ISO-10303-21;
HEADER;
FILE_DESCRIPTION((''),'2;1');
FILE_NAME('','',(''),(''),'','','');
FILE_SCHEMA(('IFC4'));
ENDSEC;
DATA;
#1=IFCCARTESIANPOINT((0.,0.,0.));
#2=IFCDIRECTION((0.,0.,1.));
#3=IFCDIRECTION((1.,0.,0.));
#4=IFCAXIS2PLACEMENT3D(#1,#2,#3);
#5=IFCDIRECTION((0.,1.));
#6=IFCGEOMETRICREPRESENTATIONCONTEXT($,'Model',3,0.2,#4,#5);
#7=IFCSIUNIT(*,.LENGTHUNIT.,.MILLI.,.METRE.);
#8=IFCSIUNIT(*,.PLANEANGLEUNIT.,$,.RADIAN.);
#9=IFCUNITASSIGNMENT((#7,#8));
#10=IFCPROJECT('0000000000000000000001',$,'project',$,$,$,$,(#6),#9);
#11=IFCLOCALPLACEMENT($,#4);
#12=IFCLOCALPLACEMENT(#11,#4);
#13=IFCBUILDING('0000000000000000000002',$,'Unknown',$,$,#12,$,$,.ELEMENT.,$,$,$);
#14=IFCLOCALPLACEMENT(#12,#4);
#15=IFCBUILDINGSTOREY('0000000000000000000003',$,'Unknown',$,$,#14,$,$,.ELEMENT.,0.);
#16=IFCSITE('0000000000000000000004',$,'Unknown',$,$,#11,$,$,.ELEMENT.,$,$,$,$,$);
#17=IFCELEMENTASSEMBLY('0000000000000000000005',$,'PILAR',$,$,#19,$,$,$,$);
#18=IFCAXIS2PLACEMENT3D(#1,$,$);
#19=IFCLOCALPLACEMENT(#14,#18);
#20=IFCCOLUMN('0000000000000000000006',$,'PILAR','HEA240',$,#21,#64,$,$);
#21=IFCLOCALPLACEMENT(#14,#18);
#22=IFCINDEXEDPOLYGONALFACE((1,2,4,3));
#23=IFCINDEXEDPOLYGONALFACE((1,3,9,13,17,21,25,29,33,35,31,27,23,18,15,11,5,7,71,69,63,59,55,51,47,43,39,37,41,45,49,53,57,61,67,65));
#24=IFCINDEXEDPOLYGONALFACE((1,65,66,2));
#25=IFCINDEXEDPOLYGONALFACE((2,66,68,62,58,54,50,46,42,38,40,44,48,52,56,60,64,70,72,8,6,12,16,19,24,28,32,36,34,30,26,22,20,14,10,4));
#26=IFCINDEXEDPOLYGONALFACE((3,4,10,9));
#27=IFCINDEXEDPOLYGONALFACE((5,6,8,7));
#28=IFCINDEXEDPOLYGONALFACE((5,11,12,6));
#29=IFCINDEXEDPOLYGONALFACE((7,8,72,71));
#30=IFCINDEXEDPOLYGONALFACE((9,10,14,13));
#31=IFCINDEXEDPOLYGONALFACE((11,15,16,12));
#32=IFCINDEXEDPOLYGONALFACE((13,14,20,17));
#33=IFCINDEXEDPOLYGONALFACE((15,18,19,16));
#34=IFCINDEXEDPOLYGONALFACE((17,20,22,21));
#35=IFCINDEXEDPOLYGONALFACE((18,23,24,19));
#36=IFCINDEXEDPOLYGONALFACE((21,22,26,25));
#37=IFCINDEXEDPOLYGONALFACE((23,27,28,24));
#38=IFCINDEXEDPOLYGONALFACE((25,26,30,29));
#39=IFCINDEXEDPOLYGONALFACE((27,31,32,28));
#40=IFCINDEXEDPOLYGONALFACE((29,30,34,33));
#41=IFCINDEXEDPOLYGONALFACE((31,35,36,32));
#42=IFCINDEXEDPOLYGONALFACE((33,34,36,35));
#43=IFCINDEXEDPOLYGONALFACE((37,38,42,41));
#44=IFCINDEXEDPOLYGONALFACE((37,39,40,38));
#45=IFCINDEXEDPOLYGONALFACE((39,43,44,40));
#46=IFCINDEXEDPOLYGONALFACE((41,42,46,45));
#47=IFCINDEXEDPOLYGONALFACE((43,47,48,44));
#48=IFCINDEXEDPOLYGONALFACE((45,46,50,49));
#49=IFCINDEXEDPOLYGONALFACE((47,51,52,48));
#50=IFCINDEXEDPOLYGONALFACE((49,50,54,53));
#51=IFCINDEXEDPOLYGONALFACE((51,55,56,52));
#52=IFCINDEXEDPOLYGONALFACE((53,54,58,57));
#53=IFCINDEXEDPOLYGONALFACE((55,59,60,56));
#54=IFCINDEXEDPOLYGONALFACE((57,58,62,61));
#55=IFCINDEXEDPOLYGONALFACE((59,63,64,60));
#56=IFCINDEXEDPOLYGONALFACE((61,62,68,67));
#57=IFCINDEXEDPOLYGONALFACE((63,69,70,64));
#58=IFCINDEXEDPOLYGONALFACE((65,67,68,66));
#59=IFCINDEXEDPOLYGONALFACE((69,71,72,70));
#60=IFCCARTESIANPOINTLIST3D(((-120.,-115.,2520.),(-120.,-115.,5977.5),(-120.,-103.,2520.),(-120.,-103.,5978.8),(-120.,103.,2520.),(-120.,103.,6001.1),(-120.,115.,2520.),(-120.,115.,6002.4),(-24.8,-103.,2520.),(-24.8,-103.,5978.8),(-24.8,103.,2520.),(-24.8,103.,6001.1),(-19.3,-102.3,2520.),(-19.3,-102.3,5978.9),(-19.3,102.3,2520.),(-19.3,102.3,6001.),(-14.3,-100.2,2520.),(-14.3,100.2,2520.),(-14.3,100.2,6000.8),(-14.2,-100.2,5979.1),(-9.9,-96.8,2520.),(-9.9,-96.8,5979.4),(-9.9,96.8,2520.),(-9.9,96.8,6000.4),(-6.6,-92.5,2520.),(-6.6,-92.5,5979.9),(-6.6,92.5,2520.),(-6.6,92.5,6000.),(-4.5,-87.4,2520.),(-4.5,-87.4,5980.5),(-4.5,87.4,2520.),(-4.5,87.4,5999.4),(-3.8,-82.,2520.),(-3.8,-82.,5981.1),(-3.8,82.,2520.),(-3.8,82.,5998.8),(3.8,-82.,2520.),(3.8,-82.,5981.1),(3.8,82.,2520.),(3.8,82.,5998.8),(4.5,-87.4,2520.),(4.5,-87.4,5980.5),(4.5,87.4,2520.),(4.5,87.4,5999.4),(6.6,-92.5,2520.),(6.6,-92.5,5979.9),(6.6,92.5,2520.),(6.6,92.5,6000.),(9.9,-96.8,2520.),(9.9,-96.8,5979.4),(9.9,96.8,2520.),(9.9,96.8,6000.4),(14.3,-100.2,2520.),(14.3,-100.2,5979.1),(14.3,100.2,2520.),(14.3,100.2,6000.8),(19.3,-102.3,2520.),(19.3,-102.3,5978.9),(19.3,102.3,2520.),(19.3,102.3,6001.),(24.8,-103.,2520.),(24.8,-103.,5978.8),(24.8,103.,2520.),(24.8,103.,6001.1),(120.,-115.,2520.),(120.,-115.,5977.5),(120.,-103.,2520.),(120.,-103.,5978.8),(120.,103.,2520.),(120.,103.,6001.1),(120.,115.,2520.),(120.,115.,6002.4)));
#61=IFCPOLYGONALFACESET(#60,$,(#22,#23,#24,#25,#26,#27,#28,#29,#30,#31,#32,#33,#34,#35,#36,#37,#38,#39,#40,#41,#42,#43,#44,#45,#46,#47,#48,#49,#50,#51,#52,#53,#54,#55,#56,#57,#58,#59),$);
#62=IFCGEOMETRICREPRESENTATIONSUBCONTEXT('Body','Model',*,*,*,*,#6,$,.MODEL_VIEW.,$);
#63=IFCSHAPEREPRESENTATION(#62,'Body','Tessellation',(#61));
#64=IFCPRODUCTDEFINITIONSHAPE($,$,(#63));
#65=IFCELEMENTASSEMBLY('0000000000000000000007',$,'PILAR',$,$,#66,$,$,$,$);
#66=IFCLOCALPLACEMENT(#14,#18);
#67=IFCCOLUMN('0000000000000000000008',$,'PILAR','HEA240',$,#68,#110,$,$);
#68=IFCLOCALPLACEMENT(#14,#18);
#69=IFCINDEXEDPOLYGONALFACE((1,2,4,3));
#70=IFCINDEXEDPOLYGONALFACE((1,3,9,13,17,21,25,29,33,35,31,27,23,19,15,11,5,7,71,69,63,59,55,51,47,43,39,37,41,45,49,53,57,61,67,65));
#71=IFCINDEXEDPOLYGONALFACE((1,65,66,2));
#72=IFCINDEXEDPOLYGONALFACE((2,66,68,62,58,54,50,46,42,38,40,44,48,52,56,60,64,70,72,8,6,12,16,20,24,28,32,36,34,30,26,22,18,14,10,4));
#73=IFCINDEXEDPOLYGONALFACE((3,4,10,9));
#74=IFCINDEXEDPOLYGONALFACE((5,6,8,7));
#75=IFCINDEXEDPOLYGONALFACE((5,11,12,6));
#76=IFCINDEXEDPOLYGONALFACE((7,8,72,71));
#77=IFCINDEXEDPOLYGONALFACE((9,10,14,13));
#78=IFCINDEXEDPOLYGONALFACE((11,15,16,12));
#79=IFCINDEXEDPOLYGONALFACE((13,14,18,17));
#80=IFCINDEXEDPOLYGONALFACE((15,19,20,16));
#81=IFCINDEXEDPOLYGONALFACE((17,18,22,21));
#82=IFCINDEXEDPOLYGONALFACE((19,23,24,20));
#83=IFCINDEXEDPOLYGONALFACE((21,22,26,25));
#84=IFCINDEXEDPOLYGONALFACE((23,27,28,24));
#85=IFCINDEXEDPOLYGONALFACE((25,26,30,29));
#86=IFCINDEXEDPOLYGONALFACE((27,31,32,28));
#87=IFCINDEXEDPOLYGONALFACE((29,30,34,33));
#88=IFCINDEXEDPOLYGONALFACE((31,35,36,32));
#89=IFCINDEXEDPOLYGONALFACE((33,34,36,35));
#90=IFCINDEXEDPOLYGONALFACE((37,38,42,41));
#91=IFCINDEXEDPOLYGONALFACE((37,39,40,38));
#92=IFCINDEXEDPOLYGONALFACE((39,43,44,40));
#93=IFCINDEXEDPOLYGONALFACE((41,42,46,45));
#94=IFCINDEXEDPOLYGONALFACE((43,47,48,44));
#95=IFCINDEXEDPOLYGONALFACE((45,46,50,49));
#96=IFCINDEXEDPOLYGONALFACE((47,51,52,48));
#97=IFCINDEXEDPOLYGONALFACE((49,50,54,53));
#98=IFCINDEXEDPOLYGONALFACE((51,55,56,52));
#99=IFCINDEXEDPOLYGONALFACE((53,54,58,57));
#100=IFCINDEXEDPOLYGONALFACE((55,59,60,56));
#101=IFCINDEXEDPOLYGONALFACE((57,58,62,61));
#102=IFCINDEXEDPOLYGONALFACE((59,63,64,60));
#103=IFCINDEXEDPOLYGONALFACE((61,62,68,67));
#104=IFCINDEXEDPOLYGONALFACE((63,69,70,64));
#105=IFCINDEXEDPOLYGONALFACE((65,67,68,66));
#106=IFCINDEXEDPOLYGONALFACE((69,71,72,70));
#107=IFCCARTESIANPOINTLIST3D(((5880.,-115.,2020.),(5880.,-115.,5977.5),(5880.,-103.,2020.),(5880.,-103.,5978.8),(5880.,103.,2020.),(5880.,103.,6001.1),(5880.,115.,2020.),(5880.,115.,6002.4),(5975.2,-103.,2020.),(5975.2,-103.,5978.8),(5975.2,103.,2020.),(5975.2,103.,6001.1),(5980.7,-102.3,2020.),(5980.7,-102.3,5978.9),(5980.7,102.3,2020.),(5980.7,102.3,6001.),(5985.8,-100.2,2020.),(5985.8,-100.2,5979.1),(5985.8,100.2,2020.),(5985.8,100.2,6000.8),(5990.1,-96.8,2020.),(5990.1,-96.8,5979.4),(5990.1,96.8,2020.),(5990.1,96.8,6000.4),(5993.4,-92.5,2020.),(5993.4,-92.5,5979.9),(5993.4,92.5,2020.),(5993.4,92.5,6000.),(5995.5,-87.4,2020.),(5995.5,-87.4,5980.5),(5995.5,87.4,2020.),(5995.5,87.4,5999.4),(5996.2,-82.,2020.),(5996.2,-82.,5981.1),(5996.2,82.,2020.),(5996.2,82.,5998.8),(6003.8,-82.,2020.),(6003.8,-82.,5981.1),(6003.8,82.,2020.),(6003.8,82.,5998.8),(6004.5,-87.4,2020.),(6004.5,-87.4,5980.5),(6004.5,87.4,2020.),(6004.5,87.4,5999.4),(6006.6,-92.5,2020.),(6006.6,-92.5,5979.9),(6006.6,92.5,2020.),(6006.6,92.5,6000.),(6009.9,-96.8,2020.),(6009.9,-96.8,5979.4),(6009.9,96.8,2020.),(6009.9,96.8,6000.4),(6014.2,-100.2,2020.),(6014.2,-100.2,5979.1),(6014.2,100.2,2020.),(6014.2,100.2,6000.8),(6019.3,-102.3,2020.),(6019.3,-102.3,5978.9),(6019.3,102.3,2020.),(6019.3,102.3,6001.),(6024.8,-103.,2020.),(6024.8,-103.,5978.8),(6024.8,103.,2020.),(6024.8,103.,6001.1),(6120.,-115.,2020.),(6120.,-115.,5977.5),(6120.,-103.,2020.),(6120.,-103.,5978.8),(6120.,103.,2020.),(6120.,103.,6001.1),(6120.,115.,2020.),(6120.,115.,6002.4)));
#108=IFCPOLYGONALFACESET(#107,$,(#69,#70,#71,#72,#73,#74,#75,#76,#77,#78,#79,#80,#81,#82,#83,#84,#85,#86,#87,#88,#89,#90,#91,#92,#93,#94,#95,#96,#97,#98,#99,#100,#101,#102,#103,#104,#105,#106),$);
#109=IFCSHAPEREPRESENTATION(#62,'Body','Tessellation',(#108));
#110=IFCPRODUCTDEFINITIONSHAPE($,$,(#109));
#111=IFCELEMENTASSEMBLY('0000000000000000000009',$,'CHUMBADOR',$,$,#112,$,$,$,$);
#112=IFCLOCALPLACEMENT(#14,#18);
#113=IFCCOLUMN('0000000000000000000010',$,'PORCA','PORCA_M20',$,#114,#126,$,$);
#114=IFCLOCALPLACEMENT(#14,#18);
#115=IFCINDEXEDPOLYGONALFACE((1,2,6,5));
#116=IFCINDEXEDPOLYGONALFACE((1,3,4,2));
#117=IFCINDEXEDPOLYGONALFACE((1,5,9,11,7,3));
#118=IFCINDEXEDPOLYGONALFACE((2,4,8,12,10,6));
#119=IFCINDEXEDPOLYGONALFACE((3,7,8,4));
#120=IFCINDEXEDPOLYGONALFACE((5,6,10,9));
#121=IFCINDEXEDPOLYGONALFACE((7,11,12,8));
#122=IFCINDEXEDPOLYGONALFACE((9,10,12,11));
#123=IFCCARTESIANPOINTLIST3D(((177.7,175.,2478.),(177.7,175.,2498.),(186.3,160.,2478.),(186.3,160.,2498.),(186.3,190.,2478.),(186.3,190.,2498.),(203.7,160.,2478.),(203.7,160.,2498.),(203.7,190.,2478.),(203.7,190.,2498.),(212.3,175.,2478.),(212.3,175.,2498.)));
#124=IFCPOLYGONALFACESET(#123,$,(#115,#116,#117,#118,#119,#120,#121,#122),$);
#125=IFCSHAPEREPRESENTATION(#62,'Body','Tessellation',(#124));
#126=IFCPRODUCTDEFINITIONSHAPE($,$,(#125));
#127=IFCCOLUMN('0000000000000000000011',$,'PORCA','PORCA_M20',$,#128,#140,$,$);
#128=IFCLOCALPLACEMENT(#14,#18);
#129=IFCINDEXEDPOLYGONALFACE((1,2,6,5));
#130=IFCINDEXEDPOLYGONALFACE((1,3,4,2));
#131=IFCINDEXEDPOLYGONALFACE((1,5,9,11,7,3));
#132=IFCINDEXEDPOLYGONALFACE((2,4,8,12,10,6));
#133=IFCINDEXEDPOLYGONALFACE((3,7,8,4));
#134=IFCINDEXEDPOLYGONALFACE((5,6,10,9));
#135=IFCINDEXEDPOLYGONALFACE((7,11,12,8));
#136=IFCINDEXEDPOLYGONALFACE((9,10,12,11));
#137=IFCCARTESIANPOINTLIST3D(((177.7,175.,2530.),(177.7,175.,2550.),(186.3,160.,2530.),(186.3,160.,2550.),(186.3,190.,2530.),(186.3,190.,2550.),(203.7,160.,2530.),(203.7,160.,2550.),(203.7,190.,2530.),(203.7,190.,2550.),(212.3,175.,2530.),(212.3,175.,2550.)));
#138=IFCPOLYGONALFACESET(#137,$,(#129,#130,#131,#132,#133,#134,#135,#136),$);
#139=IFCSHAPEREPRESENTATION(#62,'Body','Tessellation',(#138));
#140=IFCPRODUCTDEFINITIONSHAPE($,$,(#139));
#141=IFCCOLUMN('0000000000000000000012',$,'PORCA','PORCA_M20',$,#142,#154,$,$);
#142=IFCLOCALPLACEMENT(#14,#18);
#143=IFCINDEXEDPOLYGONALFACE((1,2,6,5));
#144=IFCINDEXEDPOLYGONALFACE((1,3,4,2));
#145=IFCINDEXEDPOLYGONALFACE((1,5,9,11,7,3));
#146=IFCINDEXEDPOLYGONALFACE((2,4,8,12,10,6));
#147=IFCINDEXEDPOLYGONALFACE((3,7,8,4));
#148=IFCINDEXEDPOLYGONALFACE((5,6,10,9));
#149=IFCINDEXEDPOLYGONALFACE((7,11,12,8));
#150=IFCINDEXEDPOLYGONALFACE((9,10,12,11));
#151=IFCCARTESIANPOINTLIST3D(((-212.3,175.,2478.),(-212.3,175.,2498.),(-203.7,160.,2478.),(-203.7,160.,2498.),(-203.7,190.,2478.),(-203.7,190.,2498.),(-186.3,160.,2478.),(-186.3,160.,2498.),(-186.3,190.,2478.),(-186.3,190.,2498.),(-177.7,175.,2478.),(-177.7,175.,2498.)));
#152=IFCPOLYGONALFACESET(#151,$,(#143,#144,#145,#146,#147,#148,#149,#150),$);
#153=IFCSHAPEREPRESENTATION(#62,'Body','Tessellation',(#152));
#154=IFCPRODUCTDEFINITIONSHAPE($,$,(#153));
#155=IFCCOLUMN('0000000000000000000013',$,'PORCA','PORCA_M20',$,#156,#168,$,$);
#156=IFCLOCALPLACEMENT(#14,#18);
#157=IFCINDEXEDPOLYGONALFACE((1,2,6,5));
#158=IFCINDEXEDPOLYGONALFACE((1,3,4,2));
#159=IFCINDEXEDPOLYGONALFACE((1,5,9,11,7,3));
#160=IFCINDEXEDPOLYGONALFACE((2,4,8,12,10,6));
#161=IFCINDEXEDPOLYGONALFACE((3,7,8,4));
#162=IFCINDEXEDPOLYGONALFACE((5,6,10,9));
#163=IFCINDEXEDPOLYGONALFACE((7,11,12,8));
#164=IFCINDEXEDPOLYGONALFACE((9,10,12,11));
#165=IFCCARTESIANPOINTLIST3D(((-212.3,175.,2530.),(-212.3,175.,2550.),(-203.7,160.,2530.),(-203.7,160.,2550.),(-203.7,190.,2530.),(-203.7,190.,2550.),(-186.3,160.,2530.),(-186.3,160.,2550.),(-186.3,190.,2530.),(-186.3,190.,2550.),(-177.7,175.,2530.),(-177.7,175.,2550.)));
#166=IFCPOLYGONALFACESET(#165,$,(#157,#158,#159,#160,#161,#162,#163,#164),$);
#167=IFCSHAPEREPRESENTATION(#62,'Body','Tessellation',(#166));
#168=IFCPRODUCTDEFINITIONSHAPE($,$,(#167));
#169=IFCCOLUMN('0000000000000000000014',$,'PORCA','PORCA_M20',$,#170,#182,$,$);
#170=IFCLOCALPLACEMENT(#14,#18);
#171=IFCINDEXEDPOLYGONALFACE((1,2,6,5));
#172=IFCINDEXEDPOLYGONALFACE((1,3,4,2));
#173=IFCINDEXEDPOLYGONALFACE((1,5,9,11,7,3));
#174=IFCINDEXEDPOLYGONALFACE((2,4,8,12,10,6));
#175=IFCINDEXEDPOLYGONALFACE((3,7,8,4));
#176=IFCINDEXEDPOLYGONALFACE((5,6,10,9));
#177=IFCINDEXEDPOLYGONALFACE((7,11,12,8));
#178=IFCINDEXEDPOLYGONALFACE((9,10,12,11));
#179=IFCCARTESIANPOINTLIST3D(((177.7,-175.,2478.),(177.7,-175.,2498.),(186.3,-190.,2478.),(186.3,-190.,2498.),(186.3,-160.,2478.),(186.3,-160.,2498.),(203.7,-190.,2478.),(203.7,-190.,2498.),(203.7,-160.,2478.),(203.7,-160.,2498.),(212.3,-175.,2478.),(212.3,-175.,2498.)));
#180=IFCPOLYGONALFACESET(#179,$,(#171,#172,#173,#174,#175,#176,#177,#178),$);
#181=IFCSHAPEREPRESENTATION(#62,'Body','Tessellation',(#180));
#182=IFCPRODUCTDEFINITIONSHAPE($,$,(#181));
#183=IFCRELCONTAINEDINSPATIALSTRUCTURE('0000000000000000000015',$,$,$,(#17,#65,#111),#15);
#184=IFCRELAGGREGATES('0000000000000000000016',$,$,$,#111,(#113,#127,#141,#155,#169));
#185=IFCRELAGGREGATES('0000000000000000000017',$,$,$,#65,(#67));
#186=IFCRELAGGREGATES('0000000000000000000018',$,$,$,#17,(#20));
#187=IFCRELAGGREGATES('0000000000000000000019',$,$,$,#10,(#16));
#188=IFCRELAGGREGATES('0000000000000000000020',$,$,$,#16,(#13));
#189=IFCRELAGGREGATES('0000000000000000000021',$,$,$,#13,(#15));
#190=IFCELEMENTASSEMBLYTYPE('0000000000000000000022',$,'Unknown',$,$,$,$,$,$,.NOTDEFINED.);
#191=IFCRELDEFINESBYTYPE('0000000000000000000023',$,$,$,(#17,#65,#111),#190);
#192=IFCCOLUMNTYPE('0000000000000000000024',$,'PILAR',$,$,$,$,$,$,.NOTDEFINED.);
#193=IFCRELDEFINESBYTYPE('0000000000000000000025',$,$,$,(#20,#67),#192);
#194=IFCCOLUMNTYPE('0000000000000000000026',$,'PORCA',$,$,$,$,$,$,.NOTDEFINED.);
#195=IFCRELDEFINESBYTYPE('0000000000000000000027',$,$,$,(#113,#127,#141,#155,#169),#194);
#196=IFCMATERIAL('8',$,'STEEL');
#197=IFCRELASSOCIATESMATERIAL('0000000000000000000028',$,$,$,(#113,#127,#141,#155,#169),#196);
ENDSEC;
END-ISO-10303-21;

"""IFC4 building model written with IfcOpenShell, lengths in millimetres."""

from ifc_helpers import new_model, si_unit, direction, frame, origin_with_axes, origin_2d_with_axis, place, context, subcontext, project, spatial, polyline, i_section, outline, extrude, clip, halfspace, material, material_profile, profile_set, profile_usage, type_object, element, aggregate, save


model = new_model("IFC4")

# Units and contexts
model_context = context("Model", 3, precision=0.2, world=origin_with_axes(), true_north=direction((0.0, 1.0)))
body_context = subcontext(model_context, "Body", "Model", "MODEL_VIEW")
ifc_project = project(units=[si_unit("LENGTHUNIT", "METRE", prefix="MILLI"), si_unit("PLANEANGLEUNIT", "RADIAN")], contexts=[model_context])

# Site, building, storey
site_placement = place(None, origin_with_axes())
site = spatial("IfcSite", under=ifc_project, at=site_placement, Name="Unknown", CompositionType="ELEMENT")
building_placement = place(site_placement, origin_with_axes())
building = spatial("IfcBuilding", under=site, at=building_placement, Name="Unknown", CompositionType="ELEMENT")
storey_placement = place(building_placement, origin_with_axes())
storey = spatial("IfcBuildingStorey", under=building, at=storey_placement, Name="Unknown", CompositionType="ELEMENT", Elevation=0.0)

# Element assemblies, columns
element_assembly_type = type_object("IfcElementAssemblyType", Name="Unknown", PredefinedType="NOTDEFINED")
assembly_1_placement = place(storey_placement, frame((0.0, 0.0, 2000.0), z_axis=(1.0, 0.0, 0.0), x_axis=(0.0, 0.0, 1.0)))
assembly_1 = element("IfcElementAssembly", 1, at=assembly_1_placement, inside=storey, type_object=element_assembly_type, Name="PILAR")
column_type_1 = type_object("IfcColumnType", Name="PILAR", PredefinedType="NOTDEFINED")
column_1_placement = place(assembly_1_placement, origin_with_axes())
column_1 = element("IfcColumn", 2, at=column_1_placement, type_object=column_type_1, Name="PILAR", Description="HEA240", context=body_context, shape_type="Clipping", body=[
    clip(clip(extrude(i_section(OverallWidth=240.0, OverallDepth=230.0, WebThickness=7.5, FlangeThickness=12.0, FilletRadius=21.0, FlangeEdgeRadius=0.0, FlangeSlope=0.0, at=origin_2d_with_axis()), frame((280.0, 0.0, 0.0), z_axis=(-1.0, 0.0, 0.0), x_axis=(0.0, 0.0, 1.0)), (0.0, 0.0, -1.0), 3949.9), halfspace(frame((520.0, -115.0, 0.0), z_axis=(1.0, 0.0, 0.0), x_axis=(0.0, 1.0, 0.0)), True)), halfspace(frame((3977.5, 115.0, 0.0), z_axis=(-0.994183, -0.107703, 0.0), x_axis=(0.107703, -0.994183, 0.0)), True)),
])
assembly_2_placement = place(storey_placement, frame((6000.0, 0.0, 2000.0), z_axis=(1.0, 0.0, 0.0), x_axis=(0.0, 0.0, 1.0)))
assembly_2 = element("IfcElementAssembly", 3, at=assembly_2_placement, inside=storey, type_object=element_assembly_type, Name="PILAR")
column_2_placement = place(assembly_2_placement, origin_with_axes())
column_2 = element("IfcColumn", 4, at=column_2_placement, type_object=column_type_1, Name="PILAR", Description="HEA240", context=body_context, shape_type="Clipping", body=[
    clip(clip(extrude(i_section(OverallWidth=240.0, OverallDepth=230.0, WebThickness=7.5, FlangeThickness=12.0, FilletRadius=21.0, FlangeEdgeRadius=0.0, FlangeSlope=0.0, at=origin_2d_with_axis()), frame((-220.0, 0.0, 0.0), z_axis=(-1.0, 0.0, 0.0), x_axis=(0.0, 0.0, 1.0)), (0.0, 0.0, -1.0), 4449.9), halfspace(frame((20.0, -115.0, 0.0), z_axis=(1.0, 0.0, 0.0), x_axis=(0.0, 1.0, 0.0)), True)), halfspace(frame((3977.5, 115.0, 0.0), z_axis=(-0.994183, -0.107703, 0.0), x_axis=(0.107703, -0.994183, 0.0)), True)),
])

# Element assembly, columns
assembly_3_placement = place(storey_placement, frame((-195.0, -175.0, 2445.0), z_axis=(1.0, 0.0, 0.0), x_axis=(0.0, 0.0, -1.0)))
assembly_3 = element("IfcElementAssembly", 5, at=assembly_3_placement, inside=storey, type_object=element_assembly_type, Name="CHUMBADOR")
ifc_material_1 = material(Name="8", Category="STEEL")
ifc_material_profile_1 = material_profile(ifc_material_1, outline(polyline([(8.7, -15.0), (17.3, 0.0), (8.7, 15.0), (-8.7, 15.0), (-17.3, 0.0), (-8.7, -15.0), (8.7, -15.0)])), Name="PORCA_M20")
ifc_profile_set_1 = profile_set([ifc_material_profile_1])
ifc_profile_usage_1 = profile_usage(ifc_profile_set_1, cardinal=5)
column_type_2 = type_object("IfcColumnType", Name="PORCA", PredefinedType="NOTDEFINED")
column_3_placement = place(assembly_3_placement, frame((-53.0, 350.0, 390.0), z_axis=(0.0, 0.0, 1.0), x_axis=(1.0, 0.0, 0.0)))
column_3 = element("IfcColumn", 6, at=column_3_placement, type_object=column_type_2, material=ifc_profile_usage_1, Name="PORCA", Description="PORCA_M20", context=body_context, shape_type="SolidModel", body=[
    extrude(outline(polyline([(8.7, -15.0), (17.3, 0.0), (8.7, 15.0), (-8.7, 15.0), (-17.3, 0.0), (-8.7, -15.0), (8.7, -15.0)])), frame((0.0, 0.0, 0.0), z_axis=(-1.0, 0.0, 0.0), x_axis=(0.0, 0.0, 1.0)), (0.0, 0.0, -1.0), 20.0),
])
column_4_placement = place(assembly_3_placement, frame((-105.0, 350.0, 390.0), z_axis=(0.0, 0.0, 1.0), x_axis=(1.0, 0.0, 0.0)))
column_4 = element("IfcColumn", 7, at=column_4_placement, type_object=column_type_2, material=ifc_profile_usage_1, Name="PORCA", Description="PORCA_M20", context=body_context, shape_type="SolidModel", body=[
    extrude(outline(polyline([(8.7, -15.0), (17.3, 0.0), (8.7, 15.0), (-8.7, 15.0), (-17.3, 0.0), (-8.7, -15.0), (8.7, -15.0)])), frame((0.0, 0.0, 0.0), z_axis=(-1.0, 0.0, 0.0), x_axis=(0.0, 0.0, 1.0)), (0.0, 0.0, -1.0), 20.0),
])
column_5_placement = place(assembly_3_placement, frame((-53.0, 350.0, 0.0), z_axis=(0.0, 0.0, -1.0), x_axis=(1.0, 0.0, 0.0)))
column_5 = element("IfcColumn", 8, at=column_5_placement, type_object=column_type_2, material=ifc_profile_usage_1, Name="PORCA", Description="PORCA_M20", context=body_context, shape_type="SolidModel", body=[
    extrude(outline(polyline([(8.7, -15.0), (17.3, 0.0), (8.7, 15.0), (-8.7, 15.0), (-17.3, 0.0), (-8.7, -15.0), (8.7, -15.0)])), frame((0.0, 0.0, 0.0), z_axis=(-1.0, 0.0, 0.0), x_axis=(0.0, 0.0, 1.0)), (0.0, 0.0, -1.0), 20.0),
])
column_6_placement = place(assembly_3_placement, frame((-105.0, 350.0, 0.0), z_axis=(0.0, 0.0, -1.0), x_axis=(1.0, 0.0, 0.0)))
column_6 = element("IfcColumn", 9, at=column_6_placement, type_object=column_type_2, material=ifc_profile_usage_1, Name="PORCA", Description="PORCA_M20", context=body_context, shape_type="SolidModel", body=[
    extrude(outline(polyline([(8.7, -15.0), (17.3, 0.0), (8.7, 15.0), (-8.7, 15.0), (-17.3, 0.0), (-8.7, -15.0), (8.7, -15.0)])), frame((0.0, 0.0, 0.0), z_axis=(-1.0, 0.0, 0.0), x_axis=(0.0, 0.0, 1.0)), (0.0, 0.0, -1.0), 20.0),
])
column_7_placement = place(assembly_3_placement, frame((-53.0, 0.0, 390.0), z_axis=(0.0, 0.0, 1.0), x_axis=(1.0, 0.0, 0.0)))
column_7 = element("IfcColumn", 10, at=column_7_placement, type_object=column_type_2, material=ifc_profile_usage_1, Name="PORCA", Description="PORCA_M20", context=body_context, shape_type="SolidModel", body=[
    extrude(outline(polyline([(8.7, -15.0), (17.3, 0.0), (8.7, 15.0), (-8.7, 15.0), (-17.3, 0.0), (-8.7, -15.0), (8.7, -15.0)])), frame((0.0, 0.0, 0.0), z_axis=(-1.0, 0.0, 0.0), x_axis=(0.0, 0.0, 1.0)), (0.0, 0.0, -1.0), 20.0),
])
aggregate(assembly_3, [column_3, column_4, column_5, column_6, column_7])

aggregate(assembly_2, [column_2])
aggregate(assembly_1, [column_1])

save(model, "model.ifc")
